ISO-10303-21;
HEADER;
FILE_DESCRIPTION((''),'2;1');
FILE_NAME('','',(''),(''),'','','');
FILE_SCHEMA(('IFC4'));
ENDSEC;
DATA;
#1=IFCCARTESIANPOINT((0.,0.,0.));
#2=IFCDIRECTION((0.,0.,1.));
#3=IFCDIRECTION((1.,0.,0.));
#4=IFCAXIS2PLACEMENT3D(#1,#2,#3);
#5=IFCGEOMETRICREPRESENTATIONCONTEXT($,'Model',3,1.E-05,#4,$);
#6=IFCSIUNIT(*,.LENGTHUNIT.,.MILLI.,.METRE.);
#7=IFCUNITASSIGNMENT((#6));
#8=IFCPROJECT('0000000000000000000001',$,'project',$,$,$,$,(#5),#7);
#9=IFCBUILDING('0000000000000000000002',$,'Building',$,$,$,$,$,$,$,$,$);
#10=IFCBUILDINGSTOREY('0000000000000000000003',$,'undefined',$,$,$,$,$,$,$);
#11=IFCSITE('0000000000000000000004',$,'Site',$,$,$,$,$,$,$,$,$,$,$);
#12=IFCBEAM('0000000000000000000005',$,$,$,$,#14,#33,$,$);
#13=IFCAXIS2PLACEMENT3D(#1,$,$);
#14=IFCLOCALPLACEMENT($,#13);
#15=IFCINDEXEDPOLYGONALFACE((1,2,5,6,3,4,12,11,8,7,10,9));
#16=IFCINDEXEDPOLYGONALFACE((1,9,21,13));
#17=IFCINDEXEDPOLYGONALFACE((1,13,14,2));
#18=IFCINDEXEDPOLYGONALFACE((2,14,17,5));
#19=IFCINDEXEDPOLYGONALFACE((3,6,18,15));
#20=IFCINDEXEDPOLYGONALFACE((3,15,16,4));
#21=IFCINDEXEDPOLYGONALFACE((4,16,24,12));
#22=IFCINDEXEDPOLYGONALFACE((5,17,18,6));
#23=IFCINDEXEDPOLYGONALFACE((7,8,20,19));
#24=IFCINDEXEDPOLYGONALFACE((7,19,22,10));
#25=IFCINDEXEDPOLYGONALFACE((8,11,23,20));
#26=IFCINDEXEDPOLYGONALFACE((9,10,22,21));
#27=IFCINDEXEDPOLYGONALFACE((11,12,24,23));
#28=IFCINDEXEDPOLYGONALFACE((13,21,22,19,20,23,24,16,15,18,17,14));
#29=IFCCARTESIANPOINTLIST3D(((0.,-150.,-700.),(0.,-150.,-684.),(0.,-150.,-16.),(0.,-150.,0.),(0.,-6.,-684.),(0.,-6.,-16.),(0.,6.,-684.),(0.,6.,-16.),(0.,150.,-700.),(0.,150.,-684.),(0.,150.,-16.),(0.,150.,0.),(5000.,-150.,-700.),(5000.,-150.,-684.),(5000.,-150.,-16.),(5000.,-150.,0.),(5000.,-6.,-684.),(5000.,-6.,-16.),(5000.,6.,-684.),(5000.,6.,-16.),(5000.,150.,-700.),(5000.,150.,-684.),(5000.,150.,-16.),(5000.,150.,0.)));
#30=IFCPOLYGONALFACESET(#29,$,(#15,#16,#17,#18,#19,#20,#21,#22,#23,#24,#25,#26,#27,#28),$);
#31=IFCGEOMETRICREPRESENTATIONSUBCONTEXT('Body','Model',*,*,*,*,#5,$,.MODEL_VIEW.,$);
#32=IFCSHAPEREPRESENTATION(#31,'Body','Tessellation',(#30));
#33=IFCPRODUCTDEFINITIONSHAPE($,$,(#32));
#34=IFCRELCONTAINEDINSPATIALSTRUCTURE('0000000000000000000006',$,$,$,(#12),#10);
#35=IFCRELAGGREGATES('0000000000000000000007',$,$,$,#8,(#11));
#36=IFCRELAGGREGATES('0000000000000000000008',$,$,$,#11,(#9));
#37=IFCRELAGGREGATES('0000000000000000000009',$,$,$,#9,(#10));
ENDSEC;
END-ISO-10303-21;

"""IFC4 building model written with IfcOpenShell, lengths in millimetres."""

from ifc_helpers import new_model, si_unit, frame, origin_with_axes, place, context, subcontext, project, spatial, i_section, extrude, element, save


model = new_model("IFC4")

# Units and contexts
model_context = context("Model", 3, precision=1e-05, world=origin_with_axes())
body_context = subcontext(model_context, "Body", "Model", "MODEL_VIEW")
ifc_project = project(units=[si_unit("LENGTHUNIT", "METRE", prefix="MILLI")], contexts=[model_context])

# Site, building, storey
site = spatial("IfcSite", under=ifc_project, Name="Site")
building = spatial("IfcBuilding", under=site, Name="Building")
storey = spatial("IfcBuildingStorey", under=building, Name="undefined")

# Beam
beam_placement = place(None, frame((0.0, 0.0, -350.0), z_axis=(1.0, 0.0, 0.0), x_axis=(0.0, 1.0, 0.0)))
element("IfcBeam", 1, at=beam_placement, inside=storey, context=body_context, shape_type="SweptSolid", body=[
    extrude(i_section(OverallWidth=300.0, OverallDepth=700.0, WebThickness=12.0, FlangeThickness=16.0, FilletRadius=0.0), origin_with_axes(), (0.0, 0.0, 1.0), 5000.0),
])

save(model, "model.ifc")
